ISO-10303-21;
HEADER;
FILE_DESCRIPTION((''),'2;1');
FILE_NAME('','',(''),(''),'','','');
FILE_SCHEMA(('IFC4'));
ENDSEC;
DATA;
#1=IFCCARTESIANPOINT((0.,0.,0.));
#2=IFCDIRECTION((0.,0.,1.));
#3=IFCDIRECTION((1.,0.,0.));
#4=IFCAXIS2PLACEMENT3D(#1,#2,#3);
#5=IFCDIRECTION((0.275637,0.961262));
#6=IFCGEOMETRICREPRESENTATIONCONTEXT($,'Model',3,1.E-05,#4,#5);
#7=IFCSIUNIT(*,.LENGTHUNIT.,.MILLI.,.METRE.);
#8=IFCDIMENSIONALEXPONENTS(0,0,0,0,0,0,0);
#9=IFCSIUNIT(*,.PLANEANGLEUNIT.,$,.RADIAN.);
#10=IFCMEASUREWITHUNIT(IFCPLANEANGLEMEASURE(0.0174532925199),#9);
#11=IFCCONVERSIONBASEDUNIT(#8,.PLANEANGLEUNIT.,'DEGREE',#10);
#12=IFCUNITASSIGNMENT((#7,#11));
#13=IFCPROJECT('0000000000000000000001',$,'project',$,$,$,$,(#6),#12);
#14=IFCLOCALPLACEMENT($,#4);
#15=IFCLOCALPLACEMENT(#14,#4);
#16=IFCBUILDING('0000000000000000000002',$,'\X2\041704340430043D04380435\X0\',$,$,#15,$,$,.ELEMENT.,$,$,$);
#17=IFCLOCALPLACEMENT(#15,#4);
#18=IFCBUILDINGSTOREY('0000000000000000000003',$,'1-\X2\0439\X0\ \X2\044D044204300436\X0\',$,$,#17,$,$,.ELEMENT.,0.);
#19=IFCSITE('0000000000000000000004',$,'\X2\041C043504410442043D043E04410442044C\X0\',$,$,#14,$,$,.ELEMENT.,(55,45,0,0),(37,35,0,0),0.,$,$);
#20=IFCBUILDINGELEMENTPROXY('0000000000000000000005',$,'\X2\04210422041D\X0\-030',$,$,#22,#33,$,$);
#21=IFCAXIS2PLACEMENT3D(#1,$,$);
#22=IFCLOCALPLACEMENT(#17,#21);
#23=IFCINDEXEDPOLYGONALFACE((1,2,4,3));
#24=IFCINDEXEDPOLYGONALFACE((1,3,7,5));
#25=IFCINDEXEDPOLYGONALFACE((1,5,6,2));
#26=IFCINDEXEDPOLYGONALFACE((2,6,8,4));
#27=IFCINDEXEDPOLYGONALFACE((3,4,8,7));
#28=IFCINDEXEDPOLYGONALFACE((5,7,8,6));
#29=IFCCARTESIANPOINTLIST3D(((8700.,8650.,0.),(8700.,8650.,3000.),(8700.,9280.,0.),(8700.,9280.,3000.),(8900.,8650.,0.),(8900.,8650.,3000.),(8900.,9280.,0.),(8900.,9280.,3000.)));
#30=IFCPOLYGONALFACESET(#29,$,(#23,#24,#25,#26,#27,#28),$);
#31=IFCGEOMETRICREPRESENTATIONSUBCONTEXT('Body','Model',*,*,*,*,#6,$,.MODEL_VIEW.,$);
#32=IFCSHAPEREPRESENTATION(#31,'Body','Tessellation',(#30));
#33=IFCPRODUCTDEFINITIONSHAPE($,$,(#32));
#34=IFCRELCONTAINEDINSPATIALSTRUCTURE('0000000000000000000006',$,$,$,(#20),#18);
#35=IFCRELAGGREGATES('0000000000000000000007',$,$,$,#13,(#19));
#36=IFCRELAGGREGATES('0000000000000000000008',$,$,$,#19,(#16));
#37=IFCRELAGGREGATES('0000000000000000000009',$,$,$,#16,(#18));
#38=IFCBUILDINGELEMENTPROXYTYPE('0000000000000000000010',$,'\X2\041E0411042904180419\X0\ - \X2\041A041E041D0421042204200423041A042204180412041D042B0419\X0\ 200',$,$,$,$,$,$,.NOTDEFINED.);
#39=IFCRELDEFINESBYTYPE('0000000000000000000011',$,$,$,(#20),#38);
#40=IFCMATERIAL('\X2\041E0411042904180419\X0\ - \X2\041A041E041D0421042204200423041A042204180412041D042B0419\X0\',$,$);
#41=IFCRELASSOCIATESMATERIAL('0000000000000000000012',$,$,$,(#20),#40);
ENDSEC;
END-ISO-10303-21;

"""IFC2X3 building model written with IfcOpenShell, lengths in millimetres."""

from ifc_helpers import new_model, entity, si_unit, converted_unit, direction, frame, origin_with_axes, place, context, subcontext, project, spatial, polyline, outline, extrude, material, type_object, element, save


model = new_model("IFC2X3")

# Units and contexts
model_context = context("Model", 3, precision=1e-05, world=origin_with_axes(), true_north=direction((0.275637, 0.961262)))
body_context = subcontext(model_context, "Body", "Model", "MODEL_VIEW")
ifc_project = project(units=[si_unit("LENGTHUNIT", "METRE", prefix="MILLI"), converted_unit("PLANEANGLEUNIT", "DEGREE", entity("IfcPlaneAngleMeasure", 0.0174532925199), si_unit("PLANEANGLEUNIT", "RADIAN"), dimensions=[0, 0, 0, 0, 0, 0, 0])], contexts=[model_context])

# Site, building, storey
site_placement = place(None, origin_with_axes())
site = spatial("IfcSite", under=ifc_project, at=site_placement, Name="Местность", CompositionType="ELEMENT", RefLatitude=(55, 45, 0, 0), RefLongitude=(37, 35, 0, 0), RefElevation=0.0)
building_placement = place(site_placement, origin_with_axes())
building = spatial("IfcBuilding", under=site, at=building_placement, Name="Здание", CompositionType="ELEMENT")
storey_placement = place(building_placement, origin_with_axes())
storey = spatial("IfcBuildingStorey", under=building, at=storey_placement, Name="1-й этаж", CompositionType="ELEMENT", Elevation=0.0)

# Building element proxy
ifc_material_1 = material(Name="ОБЩИЙ - КОНСТРУКТИВНЫЙ")
building_element_proxy_type = type_object("IfcBuildingElementProxyType", Name="ОБЩИЙ - КОНСТРУКТИВНЫЙ 200", PredefinedType="NOTDEFINED")
proxy_placement = place(storey_placement, frame((8900.0, 9280.0, 0.0), z_axis=(0.0, 0.0, 1.0), x_axis=(0.0, -1.0, 0.0)))
element("IfcBuildingElementProxy", 1, at=proxy_placement, inside=storey, type_object=building_element_proxy_type, material=ifc_material_1, Name="СТН-030", context=body_context, shape_type="SweptSolid", body=[
    extrude(outline(polyline([(0.0, -200.0), (630.0, -200.0), (630.0, 0.0), (0.0, 0.0), (0.0, -200.0)])), origin_with_axes(), (0.0, 0.0, 1.0), 3000.0),
])

save(model, "model.ifc")
